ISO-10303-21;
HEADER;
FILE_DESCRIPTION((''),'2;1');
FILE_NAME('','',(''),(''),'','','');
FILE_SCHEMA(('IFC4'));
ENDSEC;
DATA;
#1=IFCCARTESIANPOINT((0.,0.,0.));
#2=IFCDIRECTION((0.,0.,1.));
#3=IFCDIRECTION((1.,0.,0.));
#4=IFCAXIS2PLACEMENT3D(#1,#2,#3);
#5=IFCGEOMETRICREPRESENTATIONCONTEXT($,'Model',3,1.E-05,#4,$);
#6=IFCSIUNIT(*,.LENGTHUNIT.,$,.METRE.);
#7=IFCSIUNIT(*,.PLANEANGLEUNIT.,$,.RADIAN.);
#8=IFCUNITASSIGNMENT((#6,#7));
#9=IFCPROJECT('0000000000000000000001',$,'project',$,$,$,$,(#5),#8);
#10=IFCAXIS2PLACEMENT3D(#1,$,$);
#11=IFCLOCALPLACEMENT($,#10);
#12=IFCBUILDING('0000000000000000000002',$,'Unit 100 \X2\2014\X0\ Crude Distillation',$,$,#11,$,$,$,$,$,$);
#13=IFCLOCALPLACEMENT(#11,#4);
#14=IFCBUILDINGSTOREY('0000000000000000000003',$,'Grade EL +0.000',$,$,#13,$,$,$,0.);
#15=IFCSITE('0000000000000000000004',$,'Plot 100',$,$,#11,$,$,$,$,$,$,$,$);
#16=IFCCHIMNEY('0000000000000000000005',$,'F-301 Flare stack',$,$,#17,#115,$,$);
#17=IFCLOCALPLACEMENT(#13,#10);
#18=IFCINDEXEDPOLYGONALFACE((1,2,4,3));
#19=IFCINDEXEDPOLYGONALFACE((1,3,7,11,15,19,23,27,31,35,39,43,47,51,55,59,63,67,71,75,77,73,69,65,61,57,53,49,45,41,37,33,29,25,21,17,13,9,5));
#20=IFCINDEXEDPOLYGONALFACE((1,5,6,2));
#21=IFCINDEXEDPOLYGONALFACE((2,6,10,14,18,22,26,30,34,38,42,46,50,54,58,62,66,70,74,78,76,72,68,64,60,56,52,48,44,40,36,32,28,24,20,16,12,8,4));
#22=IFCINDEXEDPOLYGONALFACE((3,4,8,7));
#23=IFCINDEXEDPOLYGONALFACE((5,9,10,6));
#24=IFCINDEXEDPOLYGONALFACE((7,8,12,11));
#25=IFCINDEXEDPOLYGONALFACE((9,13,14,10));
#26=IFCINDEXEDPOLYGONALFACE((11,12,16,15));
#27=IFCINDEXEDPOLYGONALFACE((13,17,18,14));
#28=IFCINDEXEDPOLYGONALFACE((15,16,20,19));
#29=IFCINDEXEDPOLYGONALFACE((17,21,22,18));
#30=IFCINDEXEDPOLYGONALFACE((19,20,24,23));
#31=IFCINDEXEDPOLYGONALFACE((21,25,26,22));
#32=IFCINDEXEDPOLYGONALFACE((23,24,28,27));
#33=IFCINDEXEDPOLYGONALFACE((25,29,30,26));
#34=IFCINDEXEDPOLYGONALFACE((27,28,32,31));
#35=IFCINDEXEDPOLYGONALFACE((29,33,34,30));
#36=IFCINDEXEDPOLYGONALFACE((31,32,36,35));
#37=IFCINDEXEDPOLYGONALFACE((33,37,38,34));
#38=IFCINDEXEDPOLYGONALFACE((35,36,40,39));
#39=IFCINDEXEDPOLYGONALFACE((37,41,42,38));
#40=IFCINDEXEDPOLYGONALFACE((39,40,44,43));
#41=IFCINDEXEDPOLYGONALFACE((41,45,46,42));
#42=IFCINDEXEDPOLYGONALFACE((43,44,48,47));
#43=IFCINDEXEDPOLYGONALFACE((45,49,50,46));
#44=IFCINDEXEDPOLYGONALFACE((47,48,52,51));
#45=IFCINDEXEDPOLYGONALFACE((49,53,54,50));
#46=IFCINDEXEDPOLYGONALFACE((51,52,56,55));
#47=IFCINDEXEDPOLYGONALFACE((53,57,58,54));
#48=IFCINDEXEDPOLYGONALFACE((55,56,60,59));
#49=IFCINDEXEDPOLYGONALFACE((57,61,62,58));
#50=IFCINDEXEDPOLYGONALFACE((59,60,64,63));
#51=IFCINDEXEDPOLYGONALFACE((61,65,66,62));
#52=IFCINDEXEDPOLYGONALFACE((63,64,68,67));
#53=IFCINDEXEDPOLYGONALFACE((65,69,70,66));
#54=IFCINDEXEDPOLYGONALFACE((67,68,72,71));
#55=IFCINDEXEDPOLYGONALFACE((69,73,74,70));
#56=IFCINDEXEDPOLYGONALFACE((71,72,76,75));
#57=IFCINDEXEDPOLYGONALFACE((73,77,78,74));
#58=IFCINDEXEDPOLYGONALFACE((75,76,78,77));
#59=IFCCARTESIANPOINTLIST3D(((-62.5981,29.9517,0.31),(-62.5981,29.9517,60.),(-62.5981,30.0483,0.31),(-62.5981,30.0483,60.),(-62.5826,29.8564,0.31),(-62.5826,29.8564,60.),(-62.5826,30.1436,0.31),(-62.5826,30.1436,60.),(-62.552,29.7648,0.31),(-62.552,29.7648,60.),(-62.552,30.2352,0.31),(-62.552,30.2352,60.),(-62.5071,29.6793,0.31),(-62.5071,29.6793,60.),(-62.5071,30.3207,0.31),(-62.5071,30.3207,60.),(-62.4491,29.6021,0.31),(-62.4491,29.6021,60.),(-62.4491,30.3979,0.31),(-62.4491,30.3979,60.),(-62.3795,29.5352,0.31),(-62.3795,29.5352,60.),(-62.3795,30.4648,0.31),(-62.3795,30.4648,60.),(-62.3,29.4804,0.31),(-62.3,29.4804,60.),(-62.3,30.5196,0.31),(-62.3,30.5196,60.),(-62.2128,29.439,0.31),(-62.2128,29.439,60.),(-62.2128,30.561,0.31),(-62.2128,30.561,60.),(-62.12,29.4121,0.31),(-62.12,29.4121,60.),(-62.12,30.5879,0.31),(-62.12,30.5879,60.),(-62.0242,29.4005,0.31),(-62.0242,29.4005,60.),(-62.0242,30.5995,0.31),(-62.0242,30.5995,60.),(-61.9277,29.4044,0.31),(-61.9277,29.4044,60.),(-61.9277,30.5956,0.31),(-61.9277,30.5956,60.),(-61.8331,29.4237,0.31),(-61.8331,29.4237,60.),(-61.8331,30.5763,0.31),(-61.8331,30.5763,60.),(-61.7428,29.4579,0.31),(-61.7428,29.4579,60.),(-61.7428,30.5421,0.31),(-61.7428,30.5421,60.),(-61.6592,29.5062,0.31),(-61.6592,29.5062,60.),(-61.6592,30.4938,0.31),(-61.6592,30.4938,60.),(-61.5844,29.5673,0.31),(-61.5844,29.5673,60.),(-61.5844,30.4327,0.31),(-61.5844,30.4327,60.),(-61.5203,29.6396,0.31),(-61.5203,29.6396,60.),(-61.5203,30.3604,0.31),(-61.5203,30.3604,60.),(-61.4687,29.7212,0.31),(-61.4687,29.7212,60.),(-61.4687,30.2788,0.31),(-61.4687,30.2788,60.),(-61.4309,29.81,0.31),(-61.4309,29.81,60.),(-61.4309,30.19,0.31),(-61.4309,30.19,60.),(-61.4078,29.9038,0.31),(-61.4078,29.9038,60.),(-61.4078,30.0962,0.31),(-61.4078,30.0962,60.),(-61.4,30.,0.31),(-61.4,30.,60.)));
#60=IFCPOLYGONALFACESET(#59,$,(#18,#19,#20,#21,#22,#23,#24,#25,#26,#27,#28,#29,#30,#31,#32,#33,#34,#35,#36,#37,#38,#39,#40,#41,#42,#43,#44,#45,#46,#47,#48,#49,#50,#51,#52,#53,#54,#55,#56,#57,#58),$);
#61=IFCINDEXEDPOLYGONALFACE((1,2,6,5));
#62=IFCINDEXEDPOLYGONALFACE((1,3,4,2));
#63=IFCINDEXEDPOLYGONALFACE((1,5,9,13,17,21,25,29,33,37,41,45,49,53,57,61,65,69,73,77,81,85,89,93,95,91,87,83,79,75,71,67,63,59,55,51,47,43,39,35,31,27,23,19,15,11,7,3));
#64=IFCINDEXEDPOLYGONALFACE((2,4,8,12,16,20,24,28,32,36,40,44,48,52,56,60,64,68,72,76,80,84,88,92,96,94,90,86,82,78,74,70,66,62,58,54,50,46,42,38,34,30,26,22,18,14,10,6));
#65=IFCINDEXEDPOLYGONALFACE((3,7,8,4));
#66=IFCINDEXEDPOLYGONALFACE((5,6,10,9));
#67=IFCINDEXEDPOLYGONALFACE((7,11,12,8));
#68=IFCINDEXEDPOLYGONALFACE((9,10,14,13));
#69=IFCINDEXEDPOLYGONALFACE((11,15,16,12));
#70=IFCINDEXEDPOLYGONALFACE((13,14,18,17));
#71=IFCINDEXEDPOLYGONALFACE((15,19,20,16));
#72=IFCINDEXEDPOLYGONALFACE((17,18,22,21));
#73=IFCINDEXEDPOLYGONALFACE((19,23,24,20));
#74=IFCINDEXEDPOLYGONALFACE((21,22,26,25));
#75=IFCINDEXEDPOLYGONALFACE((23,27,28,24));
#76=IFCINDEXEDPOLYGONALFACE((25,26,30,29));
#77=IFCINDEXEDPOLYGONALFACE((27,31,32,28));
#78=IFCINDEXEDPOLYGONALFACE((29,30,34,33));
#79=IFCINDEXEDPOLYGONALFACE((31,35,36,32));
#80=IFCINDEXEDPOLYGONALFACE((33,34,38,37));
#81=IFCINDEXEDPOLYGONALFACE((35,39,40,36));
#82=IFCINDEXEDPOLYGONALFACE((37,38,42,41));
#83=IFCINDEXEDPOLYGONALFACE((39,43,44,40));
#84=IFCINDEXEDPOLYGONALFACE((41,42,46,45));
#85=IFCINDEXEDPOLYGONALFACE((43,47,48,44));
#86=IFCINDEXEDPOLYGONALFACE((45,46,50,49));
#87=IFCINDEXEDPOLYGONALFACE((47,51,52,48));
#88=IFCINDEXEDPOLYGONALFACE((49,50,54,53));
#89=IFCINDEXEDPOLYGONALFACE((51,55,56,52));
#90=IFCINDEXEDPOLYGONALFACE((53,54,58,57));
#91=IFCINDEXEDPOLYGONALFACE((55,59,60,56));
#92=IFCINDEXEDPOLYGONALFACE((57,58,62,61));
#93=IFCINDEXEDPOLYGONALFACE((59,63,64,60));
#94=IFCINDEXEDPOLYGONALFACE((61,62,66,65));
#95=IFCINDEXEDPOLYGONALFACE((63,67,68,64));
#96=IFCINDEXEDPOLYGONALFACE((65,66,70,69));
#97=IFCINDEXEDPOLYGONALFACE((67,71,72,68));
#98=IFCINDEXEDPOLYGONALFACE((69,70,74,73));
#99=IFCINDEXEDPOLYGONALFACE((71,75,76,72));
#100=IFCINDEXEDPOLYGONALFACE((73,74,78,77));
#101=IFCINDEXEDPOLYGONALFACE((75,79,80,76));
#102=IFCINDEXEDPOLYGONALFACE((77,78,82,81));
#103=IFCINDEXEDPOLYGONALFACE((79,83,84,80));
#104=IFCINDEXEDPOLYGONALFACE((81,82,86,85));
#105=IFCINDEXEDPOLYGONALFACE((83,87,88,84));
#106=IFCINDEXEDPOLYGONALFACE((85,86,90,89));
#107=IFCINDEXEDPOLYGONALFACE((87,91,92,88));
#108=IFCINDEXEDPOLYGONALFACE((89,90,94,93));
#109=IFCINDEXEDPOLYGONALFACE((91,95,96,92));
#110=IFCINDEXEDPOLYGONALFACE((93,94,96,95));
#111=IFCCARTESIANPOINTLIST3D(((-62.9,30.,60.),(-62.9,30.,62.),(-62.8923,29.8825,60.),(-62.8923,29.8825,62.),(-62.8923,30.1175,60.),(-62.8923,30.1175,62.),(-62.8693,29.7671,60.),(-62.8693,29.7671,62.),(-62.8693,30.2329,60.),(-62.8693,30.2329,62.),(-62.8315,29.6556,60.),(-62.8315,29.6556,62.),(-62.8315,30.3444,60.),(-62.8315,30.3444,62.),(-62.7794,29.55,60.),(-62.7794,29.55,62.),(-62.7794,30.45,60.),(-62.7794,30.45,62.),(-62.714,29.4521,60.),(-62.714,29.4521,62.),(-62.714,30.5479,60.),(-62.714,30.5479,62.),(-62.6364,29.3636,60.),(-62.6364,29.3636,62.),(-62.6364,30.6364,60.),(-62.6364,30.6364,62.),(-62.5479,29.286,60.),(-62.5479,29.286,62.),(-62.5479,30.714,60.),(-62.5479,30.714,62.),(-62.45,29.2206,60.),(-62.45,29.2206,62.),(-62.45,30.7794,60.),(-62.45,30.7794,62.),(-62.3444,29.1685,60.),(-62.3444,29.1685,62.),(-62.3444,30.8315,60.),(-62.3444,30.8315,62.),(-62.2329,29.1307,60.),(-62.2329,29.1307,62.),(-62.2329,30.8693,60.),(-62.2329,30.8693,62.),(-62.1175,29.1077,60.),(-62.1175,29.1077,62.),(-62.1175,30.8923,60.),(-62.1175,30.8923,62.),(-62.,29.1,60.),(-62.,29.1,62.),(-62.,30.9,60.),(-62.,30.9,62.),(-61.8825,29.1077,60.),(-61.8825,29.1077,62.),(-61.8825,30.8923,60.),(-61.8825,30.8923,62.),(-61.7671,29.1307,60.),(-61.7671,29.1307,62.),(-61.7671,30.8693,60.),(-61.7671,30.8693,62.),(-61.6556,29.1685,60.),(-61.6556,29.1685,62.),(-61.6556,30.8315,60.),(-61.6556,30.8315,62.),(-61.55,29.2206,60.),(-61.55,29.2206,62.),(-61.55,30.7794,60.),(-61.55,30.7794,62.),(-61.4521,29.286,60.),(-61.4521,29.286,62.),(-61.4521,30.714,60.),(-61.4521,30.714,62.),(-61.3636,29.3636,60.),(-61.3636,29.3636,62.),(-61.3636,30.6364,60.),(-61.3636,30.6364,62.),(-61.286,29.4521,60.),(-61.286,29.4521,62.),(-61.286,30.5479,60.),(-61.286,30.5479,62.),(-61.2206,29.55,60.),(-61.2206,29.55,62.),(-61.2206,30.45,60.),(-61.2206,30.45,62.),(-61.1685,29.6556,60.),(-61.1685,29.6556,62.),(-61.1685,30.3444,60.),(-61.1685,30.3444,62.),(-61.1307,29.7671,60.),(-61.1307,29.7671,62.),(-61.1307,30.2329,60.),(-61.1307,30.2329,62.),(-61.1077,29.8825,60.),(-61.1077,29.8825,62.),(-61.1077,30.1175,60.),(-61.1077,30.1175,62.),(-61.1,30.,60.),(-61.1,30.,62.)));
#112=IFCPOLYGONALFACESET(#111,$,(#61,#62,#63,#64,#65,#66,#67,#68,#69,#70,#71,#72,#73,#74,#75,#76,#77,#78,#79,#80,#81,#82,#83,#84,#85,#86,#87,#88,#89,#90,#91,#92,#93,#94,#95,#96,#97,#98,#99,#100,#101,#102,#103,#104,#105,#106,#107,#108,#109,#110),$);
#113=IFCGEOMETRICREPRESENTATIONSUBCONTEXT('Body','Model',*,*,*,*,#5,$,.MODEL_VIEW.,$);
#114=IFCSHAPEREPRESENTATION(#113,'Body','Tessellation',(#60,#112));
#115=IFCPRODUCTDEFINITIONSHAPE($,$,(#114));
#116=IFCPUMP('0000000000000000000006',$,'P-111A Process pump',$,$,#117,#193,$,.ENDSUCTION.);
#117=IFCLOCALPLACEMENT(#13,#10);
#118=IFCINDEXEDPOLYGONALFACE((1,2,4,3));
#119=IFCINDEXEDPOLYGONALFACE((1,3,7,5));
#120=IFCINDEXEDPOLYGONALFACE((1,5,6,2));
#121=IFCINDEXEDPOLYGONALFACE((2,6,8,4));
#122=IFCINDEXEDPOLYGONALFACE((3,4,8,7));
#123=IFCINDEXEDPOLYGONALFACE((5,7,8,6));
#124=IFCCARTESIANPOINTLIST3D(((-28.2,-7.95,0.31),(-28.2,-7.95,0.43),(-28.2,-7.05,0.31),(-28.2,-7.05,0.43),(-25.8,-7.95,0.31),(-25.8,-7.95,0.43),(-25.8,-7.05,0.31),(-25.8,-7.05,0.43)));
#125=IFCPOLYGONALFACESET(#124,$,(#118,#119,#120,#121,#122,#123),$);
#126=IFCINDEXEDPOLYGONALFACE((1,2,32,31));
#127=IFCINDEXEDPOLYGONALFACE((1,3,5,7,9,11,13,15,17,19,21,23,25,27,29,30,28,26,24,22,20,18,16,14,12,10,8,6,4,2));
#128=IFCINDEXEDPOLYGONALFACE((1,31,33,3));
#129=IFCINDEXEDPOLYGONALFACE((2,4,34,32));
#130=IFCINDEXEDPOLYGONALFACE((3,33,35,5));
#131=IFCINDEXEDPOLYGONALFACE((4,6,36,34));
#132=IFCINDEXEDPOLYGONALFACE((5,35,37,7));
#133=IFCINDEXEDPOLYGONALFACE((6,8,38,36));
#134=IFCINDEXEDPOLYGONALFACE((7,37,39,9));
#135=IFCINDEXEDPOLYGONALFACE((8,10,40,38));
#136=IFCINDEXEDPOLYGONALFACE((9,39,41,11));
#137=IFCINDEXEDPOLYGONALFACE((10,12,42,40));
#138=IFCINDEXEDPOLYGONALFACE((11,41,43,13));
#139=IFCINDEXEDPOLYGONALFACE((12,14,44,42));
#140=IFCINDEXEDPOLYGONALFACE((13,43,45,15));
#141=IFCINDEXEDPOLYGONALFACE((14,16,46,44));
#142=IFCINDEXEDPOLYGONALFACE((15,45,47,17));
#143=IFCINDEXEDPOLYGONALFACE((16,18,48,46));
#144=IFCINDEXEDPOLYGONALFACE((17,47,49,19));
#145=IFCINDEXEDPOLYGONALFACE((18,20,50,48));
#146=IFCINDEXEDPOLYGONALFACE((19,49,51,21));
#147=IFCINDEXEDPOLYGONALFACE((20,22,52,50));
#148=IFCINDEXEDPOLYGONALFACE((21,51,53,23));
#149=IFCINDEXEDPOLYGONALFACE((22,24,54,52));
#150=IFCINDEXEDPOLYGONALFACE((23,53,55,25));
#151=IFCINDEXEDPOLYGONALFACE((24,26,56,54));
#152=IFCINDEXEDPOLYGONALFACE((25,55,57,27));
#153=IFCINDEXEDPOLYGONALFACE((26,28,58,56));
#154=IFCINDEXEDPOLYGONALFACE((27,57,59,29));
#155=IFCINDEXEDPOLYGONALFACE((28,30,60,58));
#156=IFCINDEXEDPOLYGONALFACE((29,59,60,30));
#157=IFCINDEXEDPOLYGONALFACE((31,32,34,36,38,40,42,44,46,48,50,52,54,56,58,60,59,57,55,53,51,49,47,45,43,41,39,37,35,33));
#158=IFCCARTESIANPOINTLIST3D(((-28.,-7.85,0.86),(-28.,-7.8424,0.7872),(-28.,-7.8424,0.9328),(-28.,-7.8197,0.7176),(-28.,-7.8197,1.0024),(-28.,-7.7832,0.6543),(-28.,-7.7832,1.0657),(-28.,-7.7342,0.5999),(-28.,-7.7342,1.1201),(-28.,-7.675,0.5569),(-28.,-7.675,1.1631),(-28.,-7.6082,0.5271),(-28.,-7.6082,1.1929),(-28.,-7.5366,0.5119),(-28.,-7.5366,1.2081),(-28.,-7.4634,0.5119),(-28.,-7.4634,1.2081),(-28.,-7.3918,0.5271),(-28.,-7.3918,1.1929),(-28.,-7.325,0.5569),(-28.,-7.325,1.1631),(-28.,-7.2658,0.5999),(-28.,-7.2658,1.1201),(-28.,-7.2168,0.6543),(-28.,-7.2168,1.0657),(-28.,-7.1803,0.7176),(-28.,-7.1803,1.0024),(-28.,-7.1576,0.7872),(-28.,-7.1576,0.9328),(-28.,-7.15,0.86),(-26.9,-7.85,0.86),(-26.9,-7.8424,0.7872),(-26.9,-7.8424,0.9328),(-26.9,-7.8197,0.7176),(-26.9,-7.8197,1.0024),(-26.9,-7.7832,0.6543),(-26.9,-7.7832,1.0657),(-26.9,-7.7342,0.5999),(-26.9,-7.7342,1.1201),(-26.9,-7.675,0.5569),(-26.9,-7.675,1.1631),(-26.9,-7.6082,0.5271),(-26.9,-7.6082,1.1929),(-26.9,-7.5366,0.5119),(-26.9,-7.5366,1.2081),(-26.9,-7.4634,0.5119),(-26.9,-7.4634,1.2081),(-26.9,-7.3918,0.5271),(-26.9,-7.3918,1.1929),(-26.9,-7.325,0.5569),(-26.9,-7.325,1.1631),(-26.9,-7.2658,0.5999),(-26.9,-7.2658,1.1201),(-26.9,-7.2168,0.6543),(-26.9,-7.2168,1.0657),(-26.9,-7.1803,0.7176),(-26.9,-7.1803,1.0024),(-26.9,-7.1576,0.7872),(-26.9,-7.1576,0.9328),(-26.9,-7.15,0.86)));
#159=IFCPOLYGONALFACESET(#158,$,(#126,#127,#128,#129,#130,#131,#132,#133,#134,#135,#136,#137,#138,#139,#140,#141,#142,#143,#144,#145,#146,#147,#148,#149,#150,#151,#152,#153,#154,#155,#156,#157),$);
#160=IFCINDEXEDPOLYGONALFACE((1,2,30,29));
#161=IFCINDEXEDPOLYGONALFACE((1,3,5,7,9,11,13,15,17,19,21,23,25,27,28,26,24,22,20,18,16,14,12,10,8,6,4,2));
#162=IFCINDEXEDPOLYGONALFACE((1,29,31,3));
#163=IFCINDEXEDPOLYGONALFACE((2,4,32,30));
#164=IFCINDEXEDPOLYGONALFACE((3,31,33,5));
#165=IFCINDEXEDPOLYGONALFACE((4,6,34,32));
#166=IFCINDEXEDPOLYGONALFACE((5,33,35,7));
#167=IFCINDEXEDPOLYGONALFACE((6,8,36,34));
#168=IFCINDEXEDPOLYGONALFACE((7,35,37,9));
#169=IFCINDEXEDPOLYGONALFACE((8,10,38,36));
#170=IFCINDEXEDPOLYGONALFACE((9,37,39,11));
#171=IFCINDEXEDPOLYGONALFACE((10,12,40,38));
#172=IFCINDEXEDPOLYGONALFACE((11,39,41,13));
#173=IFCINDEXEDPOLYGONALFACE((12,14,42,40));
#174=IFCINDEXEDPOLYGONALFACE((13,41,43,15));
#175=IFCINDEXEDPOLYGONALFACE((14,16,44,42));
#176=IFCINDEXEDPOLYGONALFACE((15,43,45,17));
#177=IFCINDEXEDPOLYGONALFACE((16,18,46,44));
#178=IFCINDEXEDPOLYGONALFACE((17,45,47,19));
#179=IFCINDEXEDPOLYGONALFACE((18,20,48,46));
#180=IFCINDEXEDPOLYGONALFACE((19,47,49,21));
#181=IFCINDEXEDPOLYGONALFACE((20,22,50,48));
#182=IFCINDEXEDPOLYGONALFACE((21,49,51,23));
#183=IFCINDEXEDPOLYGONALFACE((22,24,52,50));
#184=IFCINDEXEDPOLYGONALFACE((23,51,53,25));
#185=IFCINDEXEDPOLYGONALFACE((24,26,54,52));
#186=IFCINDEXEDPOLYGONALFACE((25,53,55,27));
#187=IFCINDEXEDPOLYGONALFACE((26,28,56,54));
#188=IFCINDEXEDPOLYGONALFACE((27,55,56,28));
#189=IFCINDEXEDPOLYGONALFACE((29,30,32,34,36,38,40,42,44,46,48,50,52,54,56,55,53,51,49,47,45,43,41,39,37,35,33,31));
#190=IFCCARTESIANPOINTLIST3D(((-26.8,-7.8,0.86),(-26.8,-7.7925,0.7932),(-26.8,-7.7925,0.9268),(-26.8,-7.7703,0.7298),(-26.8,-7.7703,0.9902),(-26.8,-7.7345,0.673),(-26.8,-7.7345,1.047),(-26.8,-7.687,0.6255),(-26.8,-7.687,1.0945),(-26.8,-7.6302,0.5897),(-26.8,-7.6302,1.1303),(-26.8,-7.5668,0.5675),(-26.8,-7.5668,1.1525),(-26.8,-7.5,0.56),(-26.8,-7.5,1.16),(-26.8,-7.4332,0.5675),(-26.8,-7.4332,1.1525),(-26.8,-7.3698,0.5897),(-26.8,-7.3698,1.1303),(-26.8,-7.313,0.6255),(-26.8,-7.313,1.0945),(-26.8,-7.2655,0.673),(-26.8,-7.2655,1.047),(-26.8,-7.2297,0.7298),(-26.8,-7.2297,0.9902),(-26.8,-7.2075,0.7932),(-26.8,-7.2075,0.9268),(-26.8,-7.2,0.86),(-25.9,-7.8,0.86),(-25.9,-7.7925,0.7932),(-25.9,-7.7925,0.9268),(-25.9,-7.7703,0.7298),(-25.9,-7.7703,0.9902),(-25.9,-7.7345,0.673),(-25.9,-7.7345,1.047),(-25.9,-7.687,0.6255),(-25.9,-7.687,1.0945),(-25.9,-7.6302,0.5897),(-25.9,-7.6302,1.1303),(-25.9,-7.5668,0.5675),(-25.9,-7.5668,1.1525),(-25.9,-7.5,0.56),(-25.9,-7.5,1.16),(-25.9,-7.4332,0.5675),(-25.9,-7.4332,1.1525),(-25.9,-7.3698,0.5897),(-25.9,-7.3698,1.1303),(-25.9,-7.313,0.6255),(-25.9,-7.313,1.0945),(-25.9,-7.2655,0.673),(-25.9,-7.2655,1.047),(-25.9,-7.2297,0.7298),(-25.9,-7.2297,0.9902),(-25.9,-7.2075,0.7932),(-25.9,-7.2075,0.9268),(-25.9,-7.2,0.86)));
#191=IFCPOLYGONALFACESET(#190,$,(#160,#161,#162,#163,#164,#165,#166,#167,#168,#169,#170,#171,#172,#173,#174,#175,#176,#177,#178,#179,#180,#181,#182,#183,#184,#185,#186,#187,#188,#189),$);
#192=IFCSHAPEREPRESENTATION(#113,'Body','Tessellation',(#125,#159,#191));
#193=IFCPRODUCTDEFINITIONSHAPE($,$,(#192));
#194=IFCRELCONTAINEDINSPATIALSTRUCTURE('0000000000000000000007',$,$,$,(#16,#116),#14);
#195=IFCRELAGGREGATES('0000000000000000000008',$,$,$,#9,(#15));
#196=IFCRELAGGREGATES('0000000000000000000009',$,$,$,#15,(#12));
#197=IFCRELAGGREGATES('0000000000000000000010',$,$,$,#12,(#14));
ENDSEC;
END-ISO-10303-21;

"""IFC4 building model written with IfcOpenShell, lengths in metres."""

from ifc_helpers import new_model, si_unit, frame, origin, origin_with_axes, origin_2d, place, context, subcontext, project, spatial, rectangle, circle, extrude, element, save


model = new_model("IFC4")

# Units and contexts
model_context = context("Model", 3, precision=1e-05, world=origin_with_axes())
body_context = subcontext(model_context, "Body", "Model", "MODEL_VIEW")
ifc_project = project(units=[si_unit("LENGTHUNIT", "METRE"), si_unit("PLANEANGLEUNIT", "RADIAN")], contexts=[model_context])

# Site, building, storey
placement = place(None, origin())
site = spatial("IfcSite", under=ifc_project, at=placement, Name="Plot 100")
building = spatial("IfcBuilding", under=site, at=placement, Name="Unit 100 — Crude Distillation")
storey_placement = place(placement, origin_with_axes())
storey = spatial("IfcBuildingStorey", under=building, at=storey_placement, Name="Grade EL +0.000", Elevation=0.0)

# Chimney
chimney_placement = place(storey_placement, origin_with_axes())
element("IfcChimney", 1, at=chimney_placement, inside=storey, Name="F-301 Flare stack", context=body_context, shape_type="SweptSolid", body=[
    extrude(circle(Radius=0.6, at=origin_2d()), frame((-62.0, 30.0, 0.31), z_axis=(0.0, 0.0, 1.0), x_axis=(1.0, 0.0, 0.0)), (0.0, 0.0, 1.0), 59.69),
    extrude(circle(Radius=0.9, at=origin_2d()), frame((-62.0, 30.0, 60.0), z_axis=(0.0, 0.0, 1.0), x_axis=(1.0, 0.0, 0.0)), (0.0, 0.0, 1.0), 2.0),
])

# Pump
pump_1_placement = place(storey_placement, origin_with_axes())
element("IfcPump", 2, at=pump_1_placement, inside=storey, Name="P-111A Process pump", PredefinedType="ENDSUCTION", context=body_context, shape_type="SweptSolid", body=[
    extrude(rectangle(XDim=2.4, YDim=0.9, at=origin_2d()), frame((-27.0, -7.5, 0.31), z_axis=(0.0, 0.0, 1.0), x_axis=(1.0, 0.0, 0.0)), (0.0, 0.0, 1.0), 0.12),
    extrude(circle(Radius=0.35, at=origin_2d()), frame((-28.0, -7.5, 0.86), z_axis=(1.0, 0.0, 0.0), x_axis=(0.0, 1.0, 0.0)), (0.0, 0.0, 1.0), 1.1),
    extrude(circle(Radius=0.3, at=origin_2d()), frame((-26.8, -7.5, 0.86), z_axis=(1.0, 0.0, 0.0), x_axis=(0.0, 1.0, 0.0)), (0.0, 0.0, 1.0), 0.9),
])

save(model, "model.ifc")
